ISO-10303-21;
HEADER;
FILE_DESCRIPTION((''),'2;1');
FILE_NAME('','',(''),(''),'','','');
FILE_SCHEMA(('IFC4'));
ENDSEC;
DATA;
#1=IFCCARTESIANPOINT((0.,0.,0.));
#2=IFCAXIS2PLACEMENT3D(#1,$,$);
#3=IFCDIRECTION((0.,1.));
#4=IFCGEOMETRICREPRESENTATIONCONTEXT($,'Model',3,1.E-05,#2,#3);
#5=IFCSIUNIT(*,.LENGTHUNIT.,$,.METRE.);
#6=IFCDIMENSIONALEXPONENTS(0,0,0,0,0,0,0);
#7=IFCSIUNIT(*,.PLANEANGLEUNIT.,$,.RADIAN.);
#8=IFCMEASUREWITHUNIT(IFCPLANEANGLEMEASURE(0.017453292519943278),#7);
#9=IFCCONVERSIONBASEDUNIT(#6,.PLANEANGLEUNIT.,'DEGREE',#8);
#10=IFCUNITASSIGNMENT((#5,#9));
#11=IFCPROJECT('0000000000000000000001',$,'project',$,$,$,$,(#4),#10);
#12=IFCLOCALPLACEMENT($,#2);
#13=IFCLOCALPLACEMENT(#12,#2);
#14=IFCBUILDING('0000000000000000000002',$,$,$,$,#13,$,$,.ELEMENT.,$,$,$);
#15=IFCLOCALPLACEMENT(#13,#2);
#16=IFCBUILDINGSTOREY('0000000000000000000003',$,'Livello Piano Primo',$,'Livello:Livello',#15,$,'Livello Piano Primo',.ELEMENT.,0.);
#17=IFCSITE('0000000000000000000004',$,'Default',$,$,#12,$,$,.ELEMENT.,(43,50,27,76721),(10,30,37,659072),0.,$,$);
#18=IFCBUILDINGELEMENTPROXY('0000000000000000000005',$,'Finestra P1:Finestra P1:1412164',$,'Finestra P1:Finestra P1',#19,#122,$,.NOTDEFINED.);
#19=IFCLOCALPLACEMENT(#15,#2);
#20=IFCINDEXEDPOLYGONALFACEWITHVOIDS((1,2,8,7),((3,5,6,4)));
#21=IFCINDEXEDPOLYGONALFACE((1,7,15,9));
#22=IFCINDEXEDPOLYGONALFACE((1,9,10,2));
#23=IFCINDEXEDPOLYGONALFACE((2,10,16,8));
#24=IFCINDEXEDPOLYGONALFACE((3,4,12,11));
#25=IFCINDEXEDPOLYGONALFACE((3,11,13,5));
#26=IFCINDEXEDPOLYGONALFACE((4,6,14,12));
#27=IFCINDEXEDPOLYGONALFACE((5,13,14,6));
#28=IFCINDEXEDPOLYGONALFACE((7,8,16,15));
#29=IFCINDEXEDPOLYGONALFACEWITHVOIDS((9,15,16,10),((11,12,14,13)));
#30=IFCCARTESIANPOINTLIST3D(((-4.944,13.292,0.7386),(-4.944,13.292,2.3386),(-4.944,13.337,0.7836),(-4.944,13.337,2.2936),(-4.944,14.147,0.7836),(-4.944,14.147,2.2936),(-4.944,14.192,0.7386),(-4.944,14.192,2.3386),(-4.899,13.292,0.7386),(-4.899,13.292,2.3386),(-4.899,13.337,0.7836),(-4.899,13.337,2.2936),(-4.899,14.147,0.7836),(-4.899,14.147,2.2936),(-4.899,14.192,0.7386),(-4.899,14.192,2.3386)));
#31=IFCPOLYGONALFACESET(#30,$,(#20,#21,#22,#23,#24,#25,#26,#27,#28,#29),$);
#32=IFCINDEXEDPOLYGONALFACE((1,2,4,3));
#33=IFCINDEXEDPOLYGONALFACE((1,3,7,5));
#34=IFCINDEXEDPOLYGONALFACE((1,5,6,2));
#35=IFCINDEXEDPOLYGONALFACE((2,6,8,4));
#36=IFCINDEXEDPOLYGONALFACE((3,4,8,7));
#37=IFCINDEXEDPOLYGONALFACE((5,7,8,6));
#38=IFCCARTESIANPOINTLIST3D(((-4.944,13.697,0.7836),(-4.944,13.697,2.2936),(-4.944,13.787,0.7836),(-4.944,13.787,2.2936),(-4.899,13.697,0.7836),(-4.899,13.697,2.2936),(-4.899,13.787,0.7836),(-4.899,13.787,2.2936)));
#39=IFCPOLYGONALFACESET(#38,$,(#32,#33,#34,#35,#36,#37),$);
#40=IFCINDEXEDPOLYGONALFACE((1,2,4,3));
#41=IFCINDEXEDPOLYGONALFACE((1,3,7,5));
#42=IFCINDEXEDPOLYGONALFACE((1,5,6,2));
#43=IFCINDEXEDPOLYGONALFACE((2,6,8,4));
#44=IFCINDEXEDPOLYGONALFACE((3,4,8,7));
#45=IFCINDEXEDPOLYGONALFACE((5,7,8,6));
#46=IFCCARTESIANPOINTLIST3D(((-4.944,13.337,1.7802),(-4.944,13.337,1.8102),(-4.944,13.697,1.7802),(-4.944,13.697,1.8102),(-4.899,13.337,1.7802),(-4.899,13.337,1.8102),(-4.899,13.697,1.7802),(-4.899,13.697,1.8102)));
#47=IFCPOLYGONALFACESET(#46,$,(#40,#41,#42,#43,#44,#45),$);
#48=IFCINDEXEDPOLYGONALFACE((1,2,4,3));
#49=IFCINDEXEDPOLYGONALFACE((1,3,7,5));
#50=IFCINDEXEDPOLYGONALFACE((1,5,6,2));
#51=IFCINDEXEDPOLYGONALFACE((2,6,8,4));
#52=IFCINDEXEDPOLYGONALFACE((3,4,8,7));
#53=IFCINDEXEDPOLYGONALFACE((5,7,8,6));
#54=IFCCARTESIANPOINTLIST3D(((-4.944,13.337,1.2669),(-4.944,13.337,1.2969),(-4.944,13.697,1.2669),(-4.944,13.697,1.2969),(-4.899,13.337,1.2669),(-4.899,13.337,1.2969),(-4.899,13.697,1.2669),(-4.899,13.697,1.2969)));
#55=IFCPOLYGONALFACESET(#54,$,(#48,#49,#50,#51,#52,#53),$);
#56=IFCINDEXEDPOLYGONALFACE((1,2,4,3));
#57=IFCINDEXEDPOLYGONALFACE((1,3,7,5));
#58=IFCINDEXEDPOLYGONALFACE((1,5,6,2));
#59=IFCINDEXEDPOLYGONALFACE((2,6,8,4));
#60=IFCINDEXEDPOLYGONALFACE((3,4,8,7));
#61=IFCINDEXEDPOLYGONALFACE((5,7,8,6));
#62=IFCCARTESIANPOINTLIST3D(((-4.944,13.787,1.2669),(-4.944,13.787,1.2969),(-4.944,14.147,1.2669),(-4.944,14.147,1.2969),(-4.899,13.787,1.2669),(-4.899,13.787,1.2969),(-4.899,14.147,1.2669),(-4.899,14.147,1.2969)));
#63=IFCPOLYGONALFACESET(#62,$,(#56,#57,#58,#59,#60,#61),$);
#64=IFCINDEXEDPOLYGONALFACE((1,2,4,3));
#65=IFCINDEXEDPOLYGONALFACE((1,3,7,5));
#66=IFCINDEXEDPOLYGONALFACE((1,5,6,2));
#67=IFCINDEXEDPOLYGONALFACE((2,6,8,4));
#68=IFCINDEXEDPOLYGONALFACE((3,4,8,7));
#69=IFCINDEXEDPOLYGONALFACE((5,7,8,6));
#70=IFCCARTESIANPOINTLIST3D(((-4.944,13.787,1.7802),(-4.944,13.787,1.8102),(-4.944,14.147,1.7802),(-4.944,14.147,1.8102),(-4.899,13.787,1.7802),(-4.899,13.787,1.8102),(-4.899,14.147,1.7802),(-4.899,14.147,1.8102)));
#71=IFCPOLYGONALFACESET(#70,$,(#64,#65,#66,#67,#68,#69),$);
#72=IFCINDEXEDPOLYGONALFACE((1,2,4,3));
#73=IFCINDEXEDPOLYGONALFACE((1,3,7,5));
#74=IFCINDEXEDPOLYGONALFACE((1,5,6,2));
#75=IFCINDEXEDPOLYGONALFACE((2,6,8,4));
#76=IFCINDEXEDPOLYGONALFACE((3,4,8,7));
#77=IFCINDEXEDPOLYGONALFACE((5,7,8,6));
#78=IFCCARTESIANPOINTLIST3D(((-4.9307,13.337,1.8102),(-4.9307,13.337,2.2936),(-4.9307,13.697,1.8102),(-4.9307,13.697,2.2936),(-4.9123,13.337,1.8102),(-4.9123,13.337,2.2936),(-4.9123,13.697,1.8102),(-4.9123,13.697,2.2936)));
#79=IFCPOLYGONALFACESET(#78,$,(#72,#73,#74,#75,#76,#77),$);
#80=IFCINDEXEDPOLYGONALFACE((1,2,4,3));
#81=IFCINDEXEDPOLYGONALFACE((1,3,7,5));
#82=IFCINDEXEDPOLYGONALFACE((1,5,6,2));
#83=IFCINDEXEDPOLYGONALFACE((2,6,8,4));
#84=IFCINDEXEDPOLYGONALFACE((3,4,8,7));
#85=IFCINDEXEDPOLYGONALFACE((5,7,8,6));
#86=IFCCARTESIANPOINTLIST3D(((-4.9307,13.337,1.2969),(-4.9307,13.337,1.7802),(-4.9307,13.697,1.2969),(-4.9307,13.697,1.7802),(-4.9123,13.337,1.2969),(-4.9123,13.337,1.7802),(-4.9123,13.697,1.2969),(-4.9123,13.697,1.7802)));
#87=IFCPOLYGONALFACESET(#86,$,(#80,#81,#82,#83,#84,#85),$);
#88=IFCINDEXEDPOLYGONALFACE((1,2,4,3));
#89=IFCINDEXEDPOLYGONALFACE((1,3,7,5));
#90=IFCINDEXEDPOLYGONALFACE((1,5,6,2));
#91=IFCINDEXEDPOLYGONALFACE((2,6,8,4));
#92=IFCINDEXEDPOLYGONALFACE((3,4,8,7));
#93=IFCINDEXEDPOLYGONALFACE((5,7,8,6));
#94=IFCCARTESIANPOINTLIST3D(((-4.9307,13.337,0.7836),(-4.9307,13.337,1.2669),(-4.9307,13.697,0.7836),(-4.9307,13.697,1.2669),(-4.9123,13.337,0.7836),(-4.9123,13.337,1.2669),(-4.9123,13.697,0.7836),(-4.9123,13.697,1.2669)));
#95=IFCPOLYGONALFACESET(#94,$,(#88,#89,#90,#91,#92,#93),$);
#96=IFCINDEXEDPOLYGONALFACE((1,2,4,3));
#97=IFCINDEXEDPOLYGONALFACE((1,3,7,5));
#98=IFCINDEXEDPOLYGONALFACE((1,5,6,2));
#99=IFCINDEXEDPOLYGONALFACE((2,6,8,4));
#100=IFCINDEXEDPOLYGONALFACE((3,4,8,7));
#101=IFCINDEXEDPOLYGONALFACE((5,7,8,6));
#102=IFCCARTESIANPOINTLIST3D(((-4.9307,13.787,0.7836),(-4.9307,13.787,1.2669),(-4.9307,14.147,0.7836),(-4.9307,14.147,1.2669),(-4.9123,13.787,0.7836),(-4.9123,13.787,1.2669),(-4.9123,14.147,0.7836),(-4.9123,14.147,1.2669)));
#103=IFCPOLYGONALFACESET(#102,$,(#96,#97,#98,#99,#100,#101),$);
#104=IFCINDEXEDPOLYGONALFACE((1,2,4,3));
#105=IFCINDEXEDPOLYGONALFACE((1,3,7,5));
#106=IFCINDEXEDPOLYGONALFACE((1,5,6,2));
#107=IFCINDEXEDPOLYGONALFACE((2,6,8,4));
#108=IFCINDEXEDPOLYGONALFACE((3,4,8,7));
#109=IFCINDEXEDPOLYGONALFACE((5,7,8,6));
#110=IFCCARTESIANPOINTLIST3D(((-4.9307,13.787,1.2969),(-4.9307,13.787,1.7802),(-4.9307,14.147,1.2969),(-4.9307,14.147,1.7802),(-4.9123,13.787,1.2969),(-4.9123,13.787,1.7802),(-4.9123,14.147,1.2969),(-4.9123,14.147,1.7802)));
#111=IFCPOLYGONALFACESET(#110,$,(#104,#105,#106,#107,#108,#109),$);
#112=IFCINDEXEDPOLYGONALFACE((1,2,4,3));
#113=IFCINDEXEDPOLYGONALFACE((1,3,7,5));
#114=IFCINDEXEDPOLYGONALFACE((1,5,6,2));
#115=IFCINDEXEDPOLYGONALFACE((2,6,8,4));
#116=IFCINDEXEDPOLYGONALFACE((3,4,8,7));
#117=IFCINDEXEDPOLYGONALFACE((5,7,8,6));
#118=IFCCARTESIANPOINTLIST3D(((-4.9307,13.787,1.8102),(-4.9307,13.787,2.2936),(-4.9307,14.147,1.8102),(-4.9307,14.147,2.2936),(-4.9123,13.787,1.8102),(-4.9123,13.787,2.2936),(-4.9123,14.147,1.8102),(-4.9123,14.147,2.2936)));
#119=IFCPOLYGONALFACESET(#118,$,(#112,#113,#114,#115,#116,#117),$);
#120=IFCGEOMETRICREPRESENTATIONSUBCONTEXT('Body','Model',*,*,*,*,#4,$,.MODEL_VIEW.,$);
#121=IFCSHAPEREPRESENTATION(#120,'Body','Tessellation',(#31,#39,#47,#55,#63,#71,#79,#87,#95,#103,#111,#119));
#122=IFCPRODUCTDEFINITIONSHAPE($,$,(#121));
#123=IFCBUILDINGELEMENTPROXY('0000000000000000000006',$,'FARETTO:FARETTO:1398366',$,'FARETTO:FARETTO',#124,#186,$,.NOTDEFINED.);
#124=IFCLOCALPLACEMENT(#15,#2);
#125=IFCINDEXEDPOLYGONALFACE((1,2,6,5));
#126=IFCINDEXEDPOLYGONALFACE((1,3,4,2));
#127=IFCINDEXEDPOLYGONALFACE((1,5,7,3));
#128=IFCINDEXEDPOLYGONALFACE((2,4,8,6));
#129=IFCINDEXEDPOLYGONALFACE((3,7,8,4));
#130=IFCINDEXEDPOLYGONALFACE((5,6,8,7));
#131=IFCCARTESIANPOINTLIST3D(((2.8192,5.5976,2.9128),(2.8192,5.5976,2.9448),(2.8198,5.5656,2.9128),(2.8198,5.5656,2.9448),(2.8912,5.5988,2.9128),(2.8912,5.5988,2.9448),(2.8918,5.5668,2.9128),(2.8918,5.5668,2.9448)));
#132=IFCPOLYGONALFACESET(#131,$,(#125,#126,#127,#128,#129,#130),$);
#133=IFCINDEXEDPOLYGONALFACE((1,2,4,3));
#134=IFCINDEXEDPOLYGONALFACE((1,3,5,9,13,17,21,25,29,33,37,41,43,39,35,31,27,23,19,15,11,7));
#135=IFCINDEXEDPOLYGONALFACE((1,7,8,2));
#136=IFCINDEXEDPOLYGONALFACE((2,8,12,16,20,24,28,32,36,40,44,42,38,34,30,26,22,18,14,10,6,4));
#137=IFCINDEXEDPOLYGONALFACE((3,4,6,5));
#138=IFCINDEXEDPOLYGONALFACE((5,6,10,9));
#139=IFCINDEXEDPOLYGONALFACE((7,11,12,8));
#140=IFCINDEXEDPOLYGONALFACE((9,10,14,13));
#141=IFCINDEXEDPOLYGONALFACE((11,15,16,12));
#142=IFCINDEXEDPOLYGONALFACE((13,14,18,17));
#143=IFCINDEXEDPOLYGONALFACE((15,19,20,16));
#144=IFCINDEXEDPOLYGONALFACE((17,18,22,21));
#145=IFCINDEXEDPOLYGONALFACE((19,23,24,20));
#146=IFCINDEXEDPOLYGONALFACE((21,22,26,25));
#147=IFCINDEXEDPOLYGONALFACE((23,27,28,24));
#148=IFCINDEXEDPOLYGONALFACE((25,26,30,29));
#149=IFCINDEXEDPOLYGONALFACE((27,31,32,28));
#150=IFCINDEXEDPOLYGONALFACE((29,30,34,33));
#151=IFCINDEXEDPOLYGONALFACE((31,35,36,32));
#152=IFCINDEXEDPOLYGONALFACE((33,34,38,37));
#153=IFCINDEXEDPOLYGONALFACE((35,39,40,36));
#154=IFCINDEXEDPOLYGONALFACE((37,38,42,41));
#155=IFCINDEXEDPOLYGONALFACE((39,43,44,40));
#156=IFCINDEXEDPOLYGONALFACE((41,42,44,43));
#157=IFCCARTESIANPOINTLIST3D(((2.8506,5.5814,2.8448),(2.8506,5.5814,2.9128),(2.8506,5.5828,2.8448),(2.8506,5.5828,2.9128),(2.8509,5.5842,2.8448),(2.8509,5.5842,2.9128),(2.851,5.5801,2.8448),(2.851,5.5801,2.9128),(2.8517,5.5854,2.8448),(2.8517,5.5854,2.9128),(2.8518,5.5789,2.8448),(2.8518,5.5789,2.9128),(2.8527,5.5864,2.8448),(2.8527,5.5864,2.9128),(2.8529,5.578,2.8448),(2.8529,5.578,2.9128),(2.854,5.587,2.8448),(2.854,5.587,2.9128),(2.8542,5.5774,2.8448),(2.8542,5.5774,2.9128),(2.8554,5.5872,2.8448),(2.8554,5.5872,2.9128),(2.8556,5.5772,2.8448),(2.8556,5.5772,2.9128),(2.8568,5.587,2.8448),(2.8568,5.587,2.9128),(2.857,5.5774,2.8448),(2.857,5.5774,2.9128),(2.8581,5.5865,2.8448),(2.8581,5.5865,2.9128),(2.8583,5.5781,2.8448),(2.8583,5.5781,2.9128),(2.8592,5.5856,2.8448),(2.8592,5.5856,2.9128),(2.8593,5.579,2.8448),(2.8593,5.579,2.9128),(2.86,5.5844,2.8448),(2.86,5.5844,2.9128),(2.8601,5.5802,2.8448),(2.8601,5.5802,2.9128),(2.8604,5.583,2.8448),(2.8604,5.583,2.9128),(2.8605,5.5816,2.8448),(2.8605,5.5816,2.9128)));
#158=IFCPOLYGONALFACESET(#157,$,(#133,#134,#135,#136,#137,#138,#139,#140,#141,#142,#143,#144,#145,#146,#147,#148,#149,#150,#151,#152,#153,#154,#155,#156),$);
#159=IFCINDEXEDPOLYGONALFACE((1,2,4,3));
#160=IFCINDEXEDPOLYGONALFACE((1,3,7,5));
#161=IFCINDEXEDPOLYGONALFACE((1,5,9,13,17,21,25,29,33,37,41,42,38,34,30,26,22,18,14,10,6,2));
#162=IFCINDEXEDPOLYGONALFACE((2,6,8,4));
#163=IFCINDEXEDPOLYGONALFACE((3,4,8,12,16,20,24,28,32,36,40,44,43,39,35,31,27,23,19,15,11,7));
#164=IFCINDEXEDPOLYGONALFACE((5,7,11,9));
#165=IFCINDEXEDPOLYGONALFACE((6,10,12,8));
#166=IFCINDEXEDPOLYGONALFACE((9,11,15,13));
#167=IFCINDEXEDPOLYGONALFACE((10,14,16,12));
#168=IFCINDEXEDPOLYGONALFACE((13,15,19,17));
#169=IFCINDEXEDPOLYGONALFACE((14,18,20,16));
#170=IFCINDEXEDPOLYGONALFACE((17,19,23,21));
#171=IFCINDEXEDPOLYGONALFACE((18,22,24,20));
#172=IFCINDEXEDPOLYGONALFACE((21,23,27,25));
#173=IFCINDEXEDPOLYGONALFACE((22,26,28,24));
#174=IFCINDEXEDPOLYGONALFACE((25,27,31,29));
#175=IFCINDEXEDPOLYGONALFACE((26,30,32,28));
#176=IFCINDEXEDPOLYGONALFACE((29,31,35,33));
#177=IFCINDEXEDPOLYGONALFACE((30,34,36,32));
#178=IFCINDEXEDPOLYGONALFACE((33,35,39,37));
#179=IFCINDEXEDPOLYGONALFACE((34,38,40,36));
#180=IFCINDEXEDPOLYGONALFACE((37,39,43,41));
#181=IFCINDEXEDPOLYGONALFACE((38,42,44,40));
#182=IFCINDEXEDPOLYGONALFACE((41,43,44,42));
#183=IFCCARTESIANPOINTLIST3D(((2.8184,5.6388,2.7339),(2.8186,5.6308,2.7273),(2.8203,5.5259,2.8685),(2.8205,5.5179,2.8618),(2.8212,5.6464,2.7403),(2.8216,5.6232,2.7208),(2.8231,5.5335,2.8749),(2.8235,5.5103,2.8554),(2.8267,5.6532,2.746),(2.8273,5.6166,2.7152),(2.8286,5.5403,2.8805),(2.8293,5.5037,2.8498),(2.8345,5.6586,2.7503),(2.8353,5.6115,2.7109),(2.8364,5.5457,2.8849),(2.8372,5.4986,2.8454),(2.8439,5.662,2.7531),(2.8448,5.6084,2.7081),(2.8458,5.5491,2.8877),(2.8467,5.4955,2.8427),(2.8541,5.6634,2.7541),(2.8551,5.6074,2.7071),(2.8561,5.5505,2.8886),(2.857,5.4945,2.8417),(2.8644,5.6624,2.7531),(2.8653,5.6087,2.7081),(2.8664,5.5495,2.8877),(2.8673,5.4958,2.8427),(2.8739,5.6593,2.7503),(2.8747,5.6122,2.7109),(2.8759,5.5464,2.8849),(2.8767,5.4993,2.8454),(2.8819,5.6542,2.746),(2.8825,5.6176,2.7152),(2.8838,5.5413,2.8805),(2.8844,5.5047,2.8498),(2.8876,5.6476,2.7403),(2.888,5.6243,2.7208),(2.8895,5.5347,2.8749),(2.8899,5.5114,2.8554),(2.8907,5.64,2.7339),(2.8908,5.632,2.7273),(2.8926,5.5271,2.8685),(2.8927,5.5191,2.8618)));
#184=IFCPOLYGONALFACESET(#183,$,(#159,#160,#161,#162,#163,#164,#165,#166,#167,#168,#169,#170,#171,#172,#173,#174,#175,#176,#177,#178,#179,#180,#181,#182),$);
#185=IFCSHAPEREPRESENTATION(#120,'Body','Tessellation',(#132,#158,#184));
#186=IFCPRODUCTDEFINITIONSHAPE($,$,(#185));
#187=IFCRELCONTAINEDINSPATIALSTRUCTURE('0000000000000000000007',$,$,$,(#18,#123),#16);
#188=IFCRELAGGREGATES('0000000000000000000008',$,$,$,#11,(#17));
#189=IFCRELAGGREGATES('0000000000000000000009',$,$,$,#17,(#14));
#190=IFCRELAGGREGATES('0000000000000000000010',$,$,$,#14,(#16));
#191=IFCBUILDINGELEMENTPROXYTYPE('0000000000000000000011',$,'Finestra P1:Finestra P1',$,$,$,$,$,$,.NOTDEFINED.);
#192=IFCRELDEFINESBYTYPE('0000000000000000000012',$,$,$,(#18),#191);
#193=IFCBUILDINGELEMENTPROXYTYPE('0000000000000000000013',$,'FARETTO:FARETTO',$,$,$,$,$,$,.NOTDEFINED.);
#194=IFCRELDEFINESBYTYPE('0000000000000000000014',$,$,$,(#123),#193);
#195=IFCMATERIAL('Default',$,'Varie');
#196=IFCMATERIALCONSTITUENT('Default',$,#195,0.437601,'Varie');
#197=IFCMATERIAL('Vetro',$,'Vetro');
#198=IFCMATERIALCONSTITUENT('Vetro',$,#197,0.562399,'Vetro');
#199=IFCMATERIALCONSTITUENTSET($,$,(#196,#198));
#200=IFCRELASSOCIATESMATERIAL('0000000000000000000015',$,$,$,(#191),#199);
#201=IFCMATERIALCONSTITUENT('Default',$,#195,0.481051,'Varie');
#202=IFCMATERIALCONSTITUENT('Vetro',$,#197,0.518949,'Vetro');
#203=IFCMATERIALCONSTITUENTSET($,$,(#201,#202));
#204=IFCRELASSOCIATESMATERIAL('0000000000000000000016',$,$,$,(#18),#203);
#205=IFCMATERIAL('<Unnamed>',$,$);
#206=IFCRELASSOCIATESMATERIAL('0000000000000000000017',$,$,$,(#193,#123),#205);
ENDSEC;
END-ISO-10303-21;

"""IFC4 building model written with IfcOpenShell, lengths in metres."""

from ifc_helpers import new_model, entity, si_unit, converted_unit, direction, frame, origin, place, context, subcontext, project, spatial, arc, indexed_curve, outline, extrude, source, transform, mapped, material, constituent, constituent_set, type_object, type_shapes, element, save


model = new_model("IFC4")

# Units and contexts
model_context = context("Model", 3, precision=1e-05, world=origin(), true_north=direction((0.0, 1.0)))
body_context = subcontext(model_context, "Body", "Model", "MODEL_VIEW")
ifc_project = project(units=[si_unit("LENGTHUNIT", "METRE"), converted_unit("PLANEANGLEUNIT", "DEGREE", entity("IfcPlaneAngleMeasure", 0.017453292519943278), si_unit("PLANEANGLEUNIT", "RADIAN"), dimensions=[0, 0, 0, 0, 0, 0, 0])], contexts=[model_context])

# Site, building, storey
site_placement = place(None, origin())
site = spatial("IfcSite", under=ifc_project, at=site_placement, Name="Default", CompositionType="ELEMENT", RefLatitude=(43, 50, 27, 76721), RefLongitude=(10, 30, 37, 659072), RefElevation=0.0)
building_placement = place(site_placement, origin())
building = spatial("IfcBuilding", under=site, at=building_placement, CompositionType="ELEMENT")
storey_placement = place(building_placement, origin())
storey = spatial("IfcBuildingStorey", under=building, at=storey_placement, Name="Livello Piano Primo", ObjectType="Livello:Livello", LongName="Livello Piano Primo", CompositionType="ELEMENT", Elevation=0.0)

# Building element proxies
ifc_material_1 = material(Name="Default", Category="Varie")
ifc_material_2 = material(Name="Vetro", Category="Vetro")
ifc_constituent_1 = constituent(ifc_material_1, Name="Default", Category="Varie", fraction=0.437601)
ifc_constituent_2 = constituent(ifc_material_2, Name="Vetro", Category="Vetro", fraction=0.562399)
ifc_constituent_set_1 = constituent_set(constituents=[ifc_constituent_1, ifc_constituent_2])
building_element_proxy_type_1 = type_object("IfcBuildingElementProxyType", Name="Finestra P1:Finestra P1", PredefinedType="NOTDEFINED", material=ifc_constituent_set_1)
shared_shape_1 = source(origin(), body_context, "Body", "SweptSolid", [
    extrude(outline(indexed_curve([(-0.8, -0.45), (0.8, -0.45), (0.8, 0.45), (-0.8, 0.45), (-0.8, -0.45)], self_intersect=False), holes=[indexed_curve([(0.755, -0.405), (-0.755, -0.405), (-0.755, 0.405), (0.755, 0.405), (0.755, -0.405)], self_intersect=False)]), frame((0.0, -0.0225, 0.8), z_axis=(0.0, 1.0, 0.0), x_axis=(0.0, 0.0, -1.0)), (0.0, 0.0, 1.0), 0.045),
    extrude(outline(indexed_curve([(-0.045, -0.0225), (0.045, -0.0225), (0.045, 0.0225), (-0.045, 0.0225), (-0.045, -0.0225)], self_intersect=False)), frame((0.0, 0.0, 0.045), z_axis=(0.0, 0.0, 1.0), x_axis=(-1.0, 0.0, 0.0)), (0.0, 0.0, 1.0), 1.51),
    extrude(outline(indexed_curve([(-0.18, -0.0225), (0.18, -0.0225), (0.18, 0.0225), (-0.18, 0.0225), (-0.18, -0.0225)], self_intersect=False)), frame((0.225, 0.0, 1.0417)), (0.0, 0.0, 1.0), 0.03),
    extrude(outline(indexed_curve([(-0.18, -0.0225), (0.18, -0.0225), (0.18, 0.0225), (-0.18, 0.0225), (-0.18, -0.0225)], self_intersect=False)), frame((0.225, 0.0, 0.5283)), (0.0, 0.0, 1.0), 0.03),
    extrude(outline(indexed_curve([(-0.18, -0.0225), (0.18, -0.0225), (0.18, 0.0225), (-0.18, 0.0225), (-0.18, -0.0225)], self_intersect=False)), frame((-0.225, 0.0, 0.5283)), (0.0, 0.0, 1.0), 0.03),
    extrude(outline(indexed_curve([(-0.18, -0.0225), (0.18, -0.0225), (0.18, 0.0225), (-0.18, 0.0225), (-0.18, -0.0225)], self_intersect=False)), frame((-0.225, 0.0, 1.0417)), (0.0, 0.0, 1.0), 0.03),
    extrude(outline(indexed_curve([(-0.18, -0.0092), (0.18, -0.0092), (0.18, 0.0092), (-0.18, 0.0092), (-0.18, -0.0092)], self_intersect=False)), frame((0.225, 0.0, 1.0717), z_axis=(0.0, 0.0, 1.0), x_axis=(-1.0, 0.0, 0.0)), (0.0, 0.0, 1.0), 0.4833),
    extrude(outline(indexed_curve([(-0.18, -0.0092), (0.18, -0.0092), (0.18, 0.0092), (-0.18, 0.0092), (-0.18, -0.0092)], self_intersect=False)), frame((0.225, 0.0, 0.5583), z_axis=(0.0, 0.0, 1.0), x_axis=(-1.0, 0.0, 0.0)), (0.0, 0.0, 1.0), 0.4833),
    extrude(outline(indexed_curve([(-0.18, -0.0092), (0.18, -0.0092), (0.18, 0.0092), (-0.18, 0.0092), (-0.18, -0.0092)], self_intersect=False)), frame((0.225, 0.0, 0.045), z_axis=(0.0, 0.0, 1.0), x_axis=(-1.0, 0.0, 0.0)), (0.0, 0.0, 1.0), 0.4833),
    extrude(outline(indexed_curve([(-0.18, -0.0092), (0.18, -0.0092), (0.18, 0.0092), (-0.18, 0.0092), (-0.18, -0.0092)], self_intersect=False)), frame((-0.225, 0.0, 0.045), z_axis=(0.0, 0.0, 1.0), x_axis=(-1.0, 0.0, 0.0)), (0.0, 0.0, 1.0), 0.4833),
    extrude(outline(indexed_curve([(-0.18, -0.0092), (0.18, -0.0092), (0.18, 0.0092), (-0.18, 0.0092), (-0.18, -0.0092)], self_intersect=False)), frame((-0.225, 0.0, 0.5583), z_axis=(0.0, 0.0, 1.0), x_axis=(-1.0, 0.0, 0.0)), (0.0, 0.0, 1.0), 0.4833),
    extrude(outline(indexed_curve([(-0.18, -0.0092), (0.18, -0.0092), (0.18, 0.0092), (-0.18, 0.0092), (-0.18, -0.0092)], self_intersect=False)), frame((-0.225, 0.0, 1.0717), z_axis=(0.0, 0.0, 1.0), x_axis=(-1.0, 0.0, 0.0)), (0.0, 0.0, 1.0), 0.4833),
])
type_shapes(building_element_proxy_type_1, [shared_shape_1])
ifc_constituent_3 = constituent(ifc_material_1, Name="Default", Category="Varie", fraction=0.481051)
ifc_constituent_4 = constituent(ifc_material_2, Name="Vetro", Category="Vetro", fraction=0.518949)
ifc_constituent_set_2 = constituent_set(constituents=[ifc_constituent_3, ifc_constituent_4])
proxy_1_placement = place(storey_placement, frame((-4.9215, 13.742, 0.7386), z_axis=(0.0, 0.0, 1.0), x_axis=(0.0, -1.0, 0.0)))
element("IfcBuildingElementProxy", 1, at=proxy_1_placement, inside=storey, type_object=building_element_proxy_type_1, material=ifc_constituent_set_2, Name="Finestra P1:Finestra P1:1412164", ObjectType="Finestra P1:Finestra P1", PredefinedType="NOTDEFINED", context=body_context, shape_type="MappedRepresentation", body=[
    mapped(shared_shape_1, transform((0.0, 0.0, 0.0), scale=1.0)),
])
ifc_material_3 = material(Name="<Unnamed>")
building_element_proxy_type_2 = type_object("IfcBuildingElementProxyType", Name="FARETTO:FARETTO", PredefinedType="NOTDEFINED", material=ifc_material_3)
shared_shape_2 = source(origin(), body_context, "Body", "SweptSolid", [
    extrude(outline(indexed_curve([(-0.016, -0.036), (0.016, -0.036), (0.016, 0.036), (-0.016, 0.036), (-0.016, -0.036)], self_intersect=False)), frame((0.032, 0.0, 0.0), z_axis=(0.0, 0.0, 1.0), x_axis=(-1.0, 0.0, 0.0)), (0.0, 0.0, 1.0), 0.032),
    extrude(outline(indexed_curve([(-0.005, 0.0), (0.0, -0.005), (0.005, 0.0), (0.0, 0.005)], segments=[arc(1, 2, 3), arc(3, 4, 1)], self_intersect=False)), frame((0.032, 0.0, 0.032)), (0.0, 0.0, 1.0), 0.068),
    extrude(outline(indexed_curve([(-0.0365, 0.0), (0.0, -0.0365), (0.0365, 0.0), (0.0, 0.0365)], segments=[arc(1, 2, 3), arc(3, 4, 1)], self_intersect=False)), frame((-0.0277, 0.0, 0.0796), z_axis=(0.642788, 0.0, 0.766044), x_axis=(0.766044, 0.0, -0.642788)), (0.0, 0.0, 1.0), 0.1757),
])
type_shapes(building_element_proxy_type_2, [shared_shape_2])
for number, where, z_axis, x_axis, name in (
    (2, (2.8561, 5.5502, 2.9448), (0.0, 0.0, -1.0), (-0.017041, 0.999855, 0.0), "FARETTO:FARETTO:1398366"),
):
    element("IfcBuildingElementProxy", number, at=place(storey_placement, frame(where, z_axis=z_axis, x_axis=x_axis)), inside=storey, type_object=building_element_proxy_type_2, material=ifc_material_3, Name=name, ObjectType="FARETTO:FARETTO", PredefinedType="NOTDEFINED", context=body_context, shape_type="MappedRepresentation", body=[
        mapped(shared_shape_2, transform((0.0, 0.0, 0.0), scale=1.0)),
    ])

save(model, "model.ifc")
